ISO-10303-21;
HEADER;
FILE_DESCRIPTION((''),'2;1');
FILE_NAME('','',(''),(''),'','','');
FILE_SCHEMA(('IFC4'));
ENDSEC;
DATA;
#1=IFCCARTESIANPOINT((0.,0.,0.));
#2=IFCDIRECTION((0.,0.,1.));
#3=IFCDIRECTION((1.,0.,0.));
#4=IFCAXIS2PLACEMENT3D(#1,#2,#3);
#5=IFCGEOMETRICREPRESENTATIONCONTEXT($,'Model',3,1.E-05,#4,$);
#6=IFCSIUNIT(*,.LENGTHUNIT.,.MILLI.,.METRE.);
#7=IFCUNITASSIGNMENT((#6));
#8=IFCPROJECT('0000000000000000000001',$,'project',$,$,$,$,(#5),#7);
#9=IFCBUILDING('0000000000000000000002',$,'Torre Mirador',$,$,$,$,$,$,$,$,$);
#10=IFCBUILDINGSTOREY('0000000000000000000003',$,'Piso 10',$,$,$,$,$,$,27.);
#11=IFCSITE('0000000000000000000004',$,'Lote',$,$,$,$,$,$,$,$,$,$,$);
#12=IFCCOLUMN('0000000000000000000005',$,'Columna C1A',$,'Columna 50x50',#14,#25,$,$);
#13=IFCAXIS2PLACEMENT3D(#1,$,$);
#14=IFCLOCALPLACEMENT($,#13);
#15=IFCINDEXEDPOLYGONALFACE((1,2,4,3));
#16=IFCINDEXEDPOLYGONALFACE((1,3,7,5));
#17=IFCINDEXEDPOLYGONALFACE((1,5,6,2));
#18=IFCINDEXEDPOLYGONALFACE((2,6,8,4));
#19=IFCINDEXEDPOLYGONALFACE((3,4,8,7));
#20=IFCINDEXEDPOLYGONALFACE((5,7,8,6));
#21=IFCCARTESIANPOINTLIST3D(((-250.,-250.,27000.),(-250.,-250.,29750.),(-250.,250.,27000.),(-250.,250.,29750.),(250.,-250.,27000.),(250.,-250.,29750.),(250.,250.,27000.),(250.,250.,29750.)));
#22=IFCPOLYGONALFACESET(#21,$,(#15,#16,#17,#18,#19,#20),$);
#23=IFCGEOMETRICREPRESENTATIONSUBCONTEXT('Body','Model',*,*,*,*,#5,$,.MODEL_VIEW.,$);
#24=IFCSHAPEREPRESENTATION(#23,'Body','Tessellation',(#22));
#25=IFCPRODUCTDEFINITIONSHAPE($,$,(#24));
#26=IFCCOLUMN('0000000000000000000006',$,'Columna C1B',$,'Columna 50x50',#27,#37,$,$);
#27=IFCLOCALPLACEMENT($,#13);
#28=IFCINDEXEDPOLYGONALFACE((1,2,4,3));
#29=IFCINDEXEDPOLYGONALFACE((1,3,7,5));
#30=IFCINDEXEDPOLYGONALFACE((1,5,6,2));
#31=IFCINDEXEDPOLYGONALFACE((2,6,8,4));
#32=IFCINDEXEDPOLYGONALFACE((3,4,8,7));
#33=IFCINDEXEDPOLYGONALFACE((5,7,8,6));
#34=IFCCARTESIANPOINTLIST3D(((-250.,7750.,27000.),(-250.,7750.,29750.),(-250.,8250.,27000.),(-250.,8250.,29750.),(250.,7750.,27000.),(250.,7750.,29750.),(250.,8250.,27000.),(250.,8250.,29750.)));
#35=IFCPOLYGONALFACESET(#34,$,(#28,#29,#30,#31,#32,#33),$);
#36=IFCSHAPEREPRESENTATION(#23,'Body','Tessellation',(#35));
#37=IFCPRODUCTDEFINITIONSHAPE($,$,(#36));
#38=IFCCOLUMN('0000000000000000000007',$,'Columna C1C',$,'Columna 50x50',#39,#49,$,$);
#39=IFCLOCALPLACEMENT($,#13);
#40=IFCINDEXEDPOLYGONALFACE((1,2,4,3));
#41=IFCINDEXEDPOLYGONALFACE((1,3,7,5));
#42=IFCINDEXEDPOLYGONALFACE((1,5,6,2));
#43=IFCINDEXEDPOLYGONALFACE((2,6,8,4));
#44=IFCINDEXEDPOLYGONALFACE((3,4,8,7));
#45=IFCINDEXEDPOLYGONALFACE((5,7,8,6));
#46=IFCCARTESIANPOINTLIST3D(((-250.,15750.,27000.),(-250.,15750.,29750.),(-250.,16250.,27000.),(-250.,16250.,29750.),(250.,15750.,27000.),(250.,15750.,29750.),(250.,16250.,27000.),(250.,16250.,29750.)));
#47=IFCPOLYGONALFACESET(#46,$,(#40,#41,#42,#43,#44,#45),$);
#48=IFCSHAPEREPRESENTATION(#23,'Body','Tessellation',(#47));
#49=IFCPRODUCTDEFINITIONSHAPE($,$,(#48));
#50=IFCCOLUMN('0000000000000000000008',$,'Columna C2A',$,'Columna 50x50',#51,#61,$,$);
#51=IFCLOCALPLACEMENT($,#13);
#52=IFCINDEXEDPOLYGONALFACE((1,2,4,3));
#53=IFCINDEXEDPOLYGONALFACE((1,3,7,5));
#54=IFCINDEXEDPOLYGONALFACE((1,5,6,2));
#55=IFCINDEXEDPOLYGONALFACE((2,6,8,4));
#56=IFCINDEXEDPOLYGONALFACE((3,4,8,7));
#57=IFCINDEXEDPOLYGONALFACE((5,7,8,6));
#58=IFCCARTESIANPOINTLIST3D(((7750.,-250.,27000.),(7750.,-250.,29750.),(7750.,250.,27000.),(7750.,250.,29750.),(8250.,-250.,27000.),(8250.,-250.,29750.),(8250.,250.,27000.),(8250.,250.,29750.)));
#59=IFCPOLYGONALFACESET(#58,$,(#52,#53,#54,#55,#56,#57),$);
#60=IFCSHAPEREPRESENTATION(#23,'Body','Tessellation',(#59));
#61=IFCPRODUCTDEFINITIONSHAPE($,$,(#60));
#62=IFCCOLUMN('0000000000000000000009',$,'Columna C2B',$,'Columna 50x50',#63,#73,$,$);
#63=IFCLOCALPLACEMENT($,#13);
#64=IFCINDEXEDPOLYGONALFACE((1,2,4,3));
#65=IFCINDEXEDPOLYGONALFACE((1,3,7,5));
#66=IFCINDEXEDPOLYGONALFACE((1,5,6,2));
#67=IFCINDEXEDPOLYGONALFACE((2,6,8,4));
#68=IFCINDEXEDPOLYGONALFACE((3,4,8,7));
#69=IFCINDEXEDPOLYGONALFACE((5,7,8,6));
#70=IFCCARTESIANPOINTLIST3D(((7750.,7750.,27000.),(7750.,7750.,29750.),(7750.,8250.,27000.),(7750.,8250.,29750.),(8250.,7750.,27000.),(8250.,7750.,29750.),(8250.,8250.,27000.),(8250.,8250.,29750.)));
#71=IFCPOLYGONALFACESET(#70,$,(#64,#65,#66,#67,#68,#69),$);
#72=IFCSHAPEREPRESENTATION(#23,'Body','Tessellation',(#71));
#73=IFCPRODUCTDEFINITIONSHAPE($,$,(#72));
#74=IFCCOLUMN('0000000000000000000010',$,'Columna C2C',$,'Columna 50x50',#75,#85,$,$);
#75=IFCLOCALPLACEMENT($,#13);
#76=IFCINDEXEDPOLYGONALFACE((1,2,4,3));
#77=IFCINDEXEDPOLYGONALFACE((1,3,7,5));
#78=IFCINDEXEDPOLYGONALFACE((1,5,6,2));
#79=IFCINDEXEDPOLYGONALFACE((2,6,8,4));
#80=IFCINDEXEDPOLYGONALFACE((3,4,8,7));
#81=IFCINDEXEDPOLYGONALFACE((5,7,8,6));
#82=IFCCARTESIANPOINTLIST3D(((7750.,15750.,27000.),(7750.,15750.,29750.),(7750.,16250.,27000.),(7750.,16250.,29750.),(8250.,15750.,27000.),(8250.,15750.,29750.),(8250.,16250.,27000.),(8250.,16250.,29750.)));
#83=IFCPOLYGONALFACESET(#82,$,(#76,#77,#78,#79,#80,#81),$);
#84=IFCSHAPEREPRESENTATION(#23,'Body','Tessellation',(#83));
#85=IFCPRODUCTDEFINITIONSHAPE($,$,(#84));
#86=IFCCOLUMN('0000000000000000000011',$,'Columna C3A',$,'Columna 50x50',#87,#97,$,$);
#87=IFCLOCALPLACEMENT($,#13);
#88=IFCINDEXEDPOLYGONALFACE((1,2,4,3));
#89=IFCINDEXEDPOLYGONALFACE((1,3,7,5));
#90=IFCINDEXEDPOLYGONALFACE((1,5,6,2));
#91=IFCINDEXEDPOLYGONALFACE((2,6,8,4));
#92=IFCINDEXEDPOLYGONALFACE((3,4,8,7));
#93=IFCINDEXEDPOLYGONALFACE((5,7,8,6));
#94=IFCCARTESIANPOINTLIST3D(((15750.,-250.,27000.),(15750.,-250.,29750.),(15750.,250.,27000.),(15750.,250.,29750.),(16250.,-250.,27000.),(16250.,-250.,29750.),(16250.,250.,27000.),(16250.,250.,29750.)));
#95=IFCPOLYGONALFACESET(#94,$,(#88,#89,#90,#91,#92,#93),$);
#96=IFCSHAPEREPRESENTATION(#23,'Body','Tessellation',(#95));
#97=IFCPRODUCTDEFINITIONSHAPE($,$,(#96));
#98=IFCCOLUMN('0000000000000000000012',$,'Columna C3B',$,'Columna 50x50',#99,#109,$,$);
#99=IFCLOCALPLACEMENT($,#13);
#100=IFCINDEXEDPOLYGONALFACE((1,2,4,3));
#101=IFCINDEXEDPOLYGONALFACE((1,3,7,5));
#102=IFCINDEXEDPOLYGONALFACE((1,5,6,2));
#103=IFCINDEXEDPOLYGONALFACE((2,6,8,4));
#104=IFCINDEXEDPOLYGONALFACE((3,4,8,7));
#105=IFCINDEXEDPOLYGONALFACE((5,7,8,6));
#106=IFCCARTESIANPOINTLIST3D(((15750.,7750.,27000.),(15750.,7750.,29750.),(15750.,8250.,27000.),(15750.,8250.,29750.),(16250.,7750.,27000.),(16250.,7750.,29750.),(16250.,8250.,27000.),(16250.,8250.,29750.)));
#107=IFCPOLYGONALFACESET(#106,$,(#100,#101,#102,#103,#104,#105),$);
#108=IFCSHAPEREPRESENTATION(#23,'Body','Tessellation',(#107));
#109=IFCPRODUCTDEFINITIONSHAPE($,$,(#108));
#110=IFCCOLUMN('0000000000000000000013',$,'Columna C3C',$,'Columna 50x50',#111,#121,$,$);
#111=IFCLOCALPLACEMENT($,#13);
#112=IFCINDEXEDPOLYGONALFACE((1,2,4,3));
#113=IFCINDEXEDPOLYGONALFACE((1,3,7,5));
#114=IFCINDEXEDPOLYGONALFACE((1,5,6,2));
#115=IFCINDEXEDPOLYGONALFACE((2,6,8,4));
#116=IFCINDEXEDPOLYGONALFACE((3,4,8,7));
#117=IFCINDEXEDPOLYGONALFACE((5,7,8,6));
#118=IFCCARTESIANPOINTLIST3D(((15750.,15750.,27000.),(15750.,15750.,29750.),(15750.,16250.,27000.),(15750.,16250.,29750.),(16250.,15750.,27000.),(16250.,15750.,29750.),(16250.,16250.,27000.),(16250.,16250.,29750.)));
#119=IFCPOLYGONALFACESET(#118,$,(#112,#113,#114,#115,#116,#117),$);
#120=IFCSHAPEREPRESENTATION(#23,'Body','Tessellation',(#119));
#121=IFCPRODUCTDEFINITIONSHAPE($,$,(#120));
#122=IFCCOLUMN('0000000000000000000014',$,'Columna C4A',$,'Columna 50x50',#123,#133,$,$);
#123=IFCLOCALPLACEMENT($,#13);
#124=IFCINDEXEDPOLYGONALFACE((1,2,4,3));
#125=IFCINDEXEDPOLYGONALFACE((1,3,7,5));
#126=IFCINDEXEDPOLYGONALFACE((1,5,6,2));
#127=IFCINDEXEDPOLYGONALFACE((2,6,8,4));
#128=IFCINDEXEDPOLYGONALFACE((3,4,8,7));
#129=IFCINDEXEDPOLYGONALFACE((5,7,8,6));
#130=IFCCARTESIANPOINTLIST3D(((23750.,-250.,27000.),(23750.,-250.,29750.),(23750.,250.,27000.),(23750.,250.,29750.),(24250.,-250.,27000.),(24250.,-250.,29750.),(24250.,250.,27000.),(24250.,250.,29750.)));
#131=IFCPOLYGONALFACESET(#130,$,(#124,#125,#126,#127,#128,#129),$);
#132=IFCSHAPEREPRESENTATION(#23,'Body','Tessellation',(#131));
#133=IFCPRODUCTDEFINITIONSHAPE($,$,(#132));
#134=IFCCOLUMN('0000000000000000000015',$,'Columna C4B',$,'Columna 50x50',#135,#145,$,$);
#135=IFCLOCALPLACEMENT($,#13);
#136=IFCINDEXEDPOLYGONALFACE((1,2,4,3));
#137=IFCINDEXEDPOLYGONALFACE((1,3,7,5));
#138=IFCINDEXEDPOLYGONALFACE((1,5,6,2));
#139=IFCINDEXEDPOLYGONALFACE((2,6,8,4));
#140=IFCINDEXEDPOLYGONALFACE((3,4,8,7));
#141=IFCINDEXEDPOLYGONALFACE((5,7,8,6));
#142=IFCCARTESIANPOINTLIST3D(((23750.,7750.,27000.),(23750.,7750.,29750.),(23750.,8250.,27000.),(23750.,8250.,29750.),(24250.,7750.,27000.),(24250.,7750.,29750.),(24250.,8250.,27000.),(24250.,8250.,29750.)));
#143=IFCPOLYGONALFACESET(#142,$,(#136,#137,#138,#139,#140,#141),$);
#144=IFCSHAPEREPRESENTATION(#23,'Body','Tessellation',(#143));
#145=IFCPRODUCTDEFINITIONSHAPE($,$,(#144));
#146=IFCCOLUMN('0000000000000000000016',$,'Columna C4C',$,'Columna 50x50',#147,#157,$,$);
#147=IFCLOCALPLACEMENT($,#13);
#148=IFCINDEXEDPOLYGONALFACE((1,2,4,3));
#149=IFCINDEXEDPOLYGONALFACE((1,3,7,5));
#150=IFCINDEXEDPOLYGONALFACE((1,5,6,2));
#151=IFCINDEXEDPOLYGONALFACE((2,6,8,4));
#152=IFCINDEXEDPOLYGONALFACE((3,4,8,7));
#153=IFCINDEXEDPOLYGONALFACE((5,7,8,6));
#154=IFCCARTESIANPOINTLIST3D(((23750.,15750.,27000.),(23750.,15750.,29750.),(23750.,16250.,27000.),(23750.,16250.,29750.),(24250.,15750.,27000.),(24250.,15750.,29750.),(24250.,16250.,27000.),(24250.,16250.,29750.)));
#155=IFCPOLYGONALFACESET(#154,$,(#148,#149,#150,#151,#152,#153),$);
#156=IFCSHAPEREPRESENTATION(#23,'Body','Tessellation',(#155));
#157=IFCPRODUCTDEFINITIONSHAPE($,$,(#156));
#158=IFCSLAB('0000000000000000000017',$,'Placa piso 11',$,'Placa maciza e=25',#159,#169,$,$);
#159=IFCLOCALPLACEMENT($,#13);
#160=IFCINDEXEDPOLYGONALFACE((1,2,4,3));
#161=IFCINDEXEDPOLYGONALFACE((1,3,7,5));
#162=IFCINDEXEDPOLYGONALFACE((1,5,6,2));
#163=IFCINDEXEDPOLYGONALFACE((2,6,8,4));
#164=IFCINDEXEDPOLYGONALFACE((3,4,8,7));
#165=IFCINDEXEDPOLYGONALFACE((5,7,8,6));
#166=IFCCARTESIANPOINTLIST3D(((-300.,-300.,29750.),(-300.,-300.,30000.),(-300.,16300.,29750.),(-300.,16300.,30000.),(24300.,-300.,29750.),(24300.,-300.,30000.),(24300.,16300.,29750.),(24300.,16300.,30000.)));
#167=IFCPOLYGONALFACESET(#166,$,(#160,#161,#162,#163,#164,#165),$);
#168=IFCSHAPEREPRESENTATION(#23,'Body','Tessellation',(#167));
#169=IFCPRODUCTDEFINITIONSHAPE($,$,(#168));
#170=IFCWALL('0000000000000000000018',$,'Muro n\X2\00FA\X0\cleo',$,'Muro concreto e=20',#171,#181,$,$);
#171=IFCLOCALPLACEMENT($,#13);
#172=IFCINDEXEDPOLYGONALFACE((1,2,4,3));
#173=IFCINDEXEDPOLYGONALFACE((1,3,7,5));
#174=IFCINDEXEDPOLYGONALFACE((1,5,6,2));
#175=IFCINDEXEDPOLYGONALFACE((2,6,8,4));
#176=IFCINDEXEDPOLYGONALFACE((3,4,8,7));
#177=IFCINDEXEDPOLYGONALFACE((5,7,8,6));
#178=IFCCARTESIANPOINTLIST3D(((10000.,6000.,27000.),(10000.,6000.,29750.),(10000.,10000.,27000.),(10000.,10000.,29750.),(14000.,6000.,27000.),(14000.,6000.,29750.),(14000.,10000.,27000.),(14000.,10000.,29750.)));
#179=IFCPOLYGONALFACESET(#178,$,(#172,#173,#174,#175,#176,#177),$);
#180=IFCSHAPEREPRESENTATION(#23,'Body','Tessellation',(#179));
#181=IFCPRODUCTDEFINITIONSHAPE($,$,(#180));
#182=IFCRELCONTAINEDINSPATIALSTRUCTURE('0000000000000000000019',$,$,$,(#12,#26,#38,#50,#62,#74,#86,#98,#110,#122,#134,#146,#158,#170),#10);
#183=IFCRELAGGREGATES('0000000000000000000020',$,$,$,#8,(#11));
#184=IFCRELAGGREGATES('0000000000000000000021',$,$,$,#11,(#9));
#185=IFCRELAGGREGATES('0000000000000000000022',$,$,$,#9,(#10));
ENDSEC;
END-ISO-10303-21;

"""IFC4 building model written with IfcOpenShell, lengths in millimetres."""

from ifc_helpers import new_model, si_unit, frame, origin_with_axes, place, context, subcontext, project, spatial, indexed_curve, outline, extrude, element, save


model = new_model("IFC4")

# Units and contexts
model_context = context("Model", 3, precision=1e-05, world=origin_with_axes())
body_context = subcontext(model_context, "Body", "Model", "MODEL_VIEW")
ifc_project = project(units=[si_unit("LENGTHUNIT", "METRE", prefix="MILLI")], contexts=[model_context])

# Site, building, storey
site = spatial("IfcSite", under=ifc_project, Name="Lote")
building = spatial("IfcBuilding", under=site, Name="Torre Mirador")
storey = spatial("IfcBuildingStorey", under=building, Name="Piso 10", Elevation=27.0)

# Columns
for number, where, z_axis, x_axis, name in (
    (1, (-250.0, -250.0, 27000.0), (0.0, 0.0, 1.0), (1.0, 0.0, 0.0), "Columna C1A"),
    (2, (-250.0, 7750.0, 27000.0), (0.0, 0.0, 1.0), (1.0, 0.0, 0.0), "Columna C1B"),
    (3, (-250.0, 15750.0, 27000.0), (0.0, 0.0, 1.0), (1.0, 0.0, 0.0), "Columna C1C"),
    (4, (7750.0, -250.0, 27000.0), (0.0, 0.0, 1.0), (1.0, 0.0, 0.0), "Columna C2A"),
    (5, (7750.0, 7750.0, 27000.0), (0.0, 0.0, 1.0), (1.0, 0.0, 0.0), "Columna C2B"),
    (6, (7750.0, 15750.0, 27000.0), (0.0, 0.0, 1.0), (1.0, 0.0, 0.0), "Columna C2C"),
    (7, (15750.0, -250.0, 27000.0), (0.0, 0.0, 1.0), (1.0, 0.0, 0.0), "Columna C3A"),
    (8, (15750.0, 7750.0, 27000.0), (0.0, 0.0, 1.0), (1.0, 0.0, 0.0), "Columna C3B"),
    (9, (15750.0, 15750.0, 27000.0), (0.0, 0.0, 1.0), (1.0, 0.0, 0.0), "Columna C3C"),
    (10, (23750.0, -250.0, 27000.0), (0.0, 0.0, 1.0), (1.0, 0.0, 0.0), "Columna C4A"),
    (11, (23750.0, 7750.0, 27000.0), (0.0, 0.0, 1.0), (1.0, 0.0, 0.0), "Columna C4B"),
    (12, (23750.0, 15750.0, 27000.0), (0.0, 0.0, 1.0), (1.0, 0.0, 0.0), "Columna C4C"),
):
    element("IfcColumn", number, at=place(None, frame(where, z_axis=z_axis, x_axis=x_axis)), inside=storey, Name=name, ObjectType="Columna 50x50", context=body_context, shape_type="SweptSolid", body=[
        extrude(outline(indexed_curve([(0.0, 0.0), (0.0, 500.0), (500.0, 500.0), (500.0, 0.0), (0.0, 0.0)], self_intersect=False)), origin_with_axes(), (0.0, 0.0, 1.0), 2750.0),
    ])

# Slab
slab_placement = place(None, frame((-300.0, -300.0, 29750.0), z_axis=(0.0, 0.0, 1.0), x_axis=(1.0, 0.0, 0.0)))
element("IfcSlab", 13, at=slab_placement, inside=storey, Name="Placa piso 11", ObjectType="Placa maciza e=25", context=body_context, shape_type="SweptSolid", body=[
    extrude(outline(indexed_curve([(0.0, 0.0), (0.0, 16600.0), (24600.0, 16600.0), (24600.0, 0.0), (0.0, 0.0)], self_intersect=False)), origin_with_axes(), (0.0, 0.0, 1.0), 250.0),
])

# Wall
wall_placement = place(None, frame((10000.0, 6000.0, 27000.0), z_axis=(0.0, 0.0, 1.0), x_axis=(1.0, 0.0, 0.0)))
element("IfcWall", 14, at=wall_placement, inside=storey, Name="Muro núcleo", ObjectType="Muro concreto e=20", context=body_context, shape_type="SweptSolid", body=[
    extrude(outline(indexed_curve([(0.0, 0.0), (0.0, 4000.0), (4000.0, 4000.0), (4000.0, 0.0), (0.0, 0.0)], self_intersect=False)), origin_with_axes(), (0.0, 0.0, 1.0), 2750.0),
])

save(model, "model.ifc")
